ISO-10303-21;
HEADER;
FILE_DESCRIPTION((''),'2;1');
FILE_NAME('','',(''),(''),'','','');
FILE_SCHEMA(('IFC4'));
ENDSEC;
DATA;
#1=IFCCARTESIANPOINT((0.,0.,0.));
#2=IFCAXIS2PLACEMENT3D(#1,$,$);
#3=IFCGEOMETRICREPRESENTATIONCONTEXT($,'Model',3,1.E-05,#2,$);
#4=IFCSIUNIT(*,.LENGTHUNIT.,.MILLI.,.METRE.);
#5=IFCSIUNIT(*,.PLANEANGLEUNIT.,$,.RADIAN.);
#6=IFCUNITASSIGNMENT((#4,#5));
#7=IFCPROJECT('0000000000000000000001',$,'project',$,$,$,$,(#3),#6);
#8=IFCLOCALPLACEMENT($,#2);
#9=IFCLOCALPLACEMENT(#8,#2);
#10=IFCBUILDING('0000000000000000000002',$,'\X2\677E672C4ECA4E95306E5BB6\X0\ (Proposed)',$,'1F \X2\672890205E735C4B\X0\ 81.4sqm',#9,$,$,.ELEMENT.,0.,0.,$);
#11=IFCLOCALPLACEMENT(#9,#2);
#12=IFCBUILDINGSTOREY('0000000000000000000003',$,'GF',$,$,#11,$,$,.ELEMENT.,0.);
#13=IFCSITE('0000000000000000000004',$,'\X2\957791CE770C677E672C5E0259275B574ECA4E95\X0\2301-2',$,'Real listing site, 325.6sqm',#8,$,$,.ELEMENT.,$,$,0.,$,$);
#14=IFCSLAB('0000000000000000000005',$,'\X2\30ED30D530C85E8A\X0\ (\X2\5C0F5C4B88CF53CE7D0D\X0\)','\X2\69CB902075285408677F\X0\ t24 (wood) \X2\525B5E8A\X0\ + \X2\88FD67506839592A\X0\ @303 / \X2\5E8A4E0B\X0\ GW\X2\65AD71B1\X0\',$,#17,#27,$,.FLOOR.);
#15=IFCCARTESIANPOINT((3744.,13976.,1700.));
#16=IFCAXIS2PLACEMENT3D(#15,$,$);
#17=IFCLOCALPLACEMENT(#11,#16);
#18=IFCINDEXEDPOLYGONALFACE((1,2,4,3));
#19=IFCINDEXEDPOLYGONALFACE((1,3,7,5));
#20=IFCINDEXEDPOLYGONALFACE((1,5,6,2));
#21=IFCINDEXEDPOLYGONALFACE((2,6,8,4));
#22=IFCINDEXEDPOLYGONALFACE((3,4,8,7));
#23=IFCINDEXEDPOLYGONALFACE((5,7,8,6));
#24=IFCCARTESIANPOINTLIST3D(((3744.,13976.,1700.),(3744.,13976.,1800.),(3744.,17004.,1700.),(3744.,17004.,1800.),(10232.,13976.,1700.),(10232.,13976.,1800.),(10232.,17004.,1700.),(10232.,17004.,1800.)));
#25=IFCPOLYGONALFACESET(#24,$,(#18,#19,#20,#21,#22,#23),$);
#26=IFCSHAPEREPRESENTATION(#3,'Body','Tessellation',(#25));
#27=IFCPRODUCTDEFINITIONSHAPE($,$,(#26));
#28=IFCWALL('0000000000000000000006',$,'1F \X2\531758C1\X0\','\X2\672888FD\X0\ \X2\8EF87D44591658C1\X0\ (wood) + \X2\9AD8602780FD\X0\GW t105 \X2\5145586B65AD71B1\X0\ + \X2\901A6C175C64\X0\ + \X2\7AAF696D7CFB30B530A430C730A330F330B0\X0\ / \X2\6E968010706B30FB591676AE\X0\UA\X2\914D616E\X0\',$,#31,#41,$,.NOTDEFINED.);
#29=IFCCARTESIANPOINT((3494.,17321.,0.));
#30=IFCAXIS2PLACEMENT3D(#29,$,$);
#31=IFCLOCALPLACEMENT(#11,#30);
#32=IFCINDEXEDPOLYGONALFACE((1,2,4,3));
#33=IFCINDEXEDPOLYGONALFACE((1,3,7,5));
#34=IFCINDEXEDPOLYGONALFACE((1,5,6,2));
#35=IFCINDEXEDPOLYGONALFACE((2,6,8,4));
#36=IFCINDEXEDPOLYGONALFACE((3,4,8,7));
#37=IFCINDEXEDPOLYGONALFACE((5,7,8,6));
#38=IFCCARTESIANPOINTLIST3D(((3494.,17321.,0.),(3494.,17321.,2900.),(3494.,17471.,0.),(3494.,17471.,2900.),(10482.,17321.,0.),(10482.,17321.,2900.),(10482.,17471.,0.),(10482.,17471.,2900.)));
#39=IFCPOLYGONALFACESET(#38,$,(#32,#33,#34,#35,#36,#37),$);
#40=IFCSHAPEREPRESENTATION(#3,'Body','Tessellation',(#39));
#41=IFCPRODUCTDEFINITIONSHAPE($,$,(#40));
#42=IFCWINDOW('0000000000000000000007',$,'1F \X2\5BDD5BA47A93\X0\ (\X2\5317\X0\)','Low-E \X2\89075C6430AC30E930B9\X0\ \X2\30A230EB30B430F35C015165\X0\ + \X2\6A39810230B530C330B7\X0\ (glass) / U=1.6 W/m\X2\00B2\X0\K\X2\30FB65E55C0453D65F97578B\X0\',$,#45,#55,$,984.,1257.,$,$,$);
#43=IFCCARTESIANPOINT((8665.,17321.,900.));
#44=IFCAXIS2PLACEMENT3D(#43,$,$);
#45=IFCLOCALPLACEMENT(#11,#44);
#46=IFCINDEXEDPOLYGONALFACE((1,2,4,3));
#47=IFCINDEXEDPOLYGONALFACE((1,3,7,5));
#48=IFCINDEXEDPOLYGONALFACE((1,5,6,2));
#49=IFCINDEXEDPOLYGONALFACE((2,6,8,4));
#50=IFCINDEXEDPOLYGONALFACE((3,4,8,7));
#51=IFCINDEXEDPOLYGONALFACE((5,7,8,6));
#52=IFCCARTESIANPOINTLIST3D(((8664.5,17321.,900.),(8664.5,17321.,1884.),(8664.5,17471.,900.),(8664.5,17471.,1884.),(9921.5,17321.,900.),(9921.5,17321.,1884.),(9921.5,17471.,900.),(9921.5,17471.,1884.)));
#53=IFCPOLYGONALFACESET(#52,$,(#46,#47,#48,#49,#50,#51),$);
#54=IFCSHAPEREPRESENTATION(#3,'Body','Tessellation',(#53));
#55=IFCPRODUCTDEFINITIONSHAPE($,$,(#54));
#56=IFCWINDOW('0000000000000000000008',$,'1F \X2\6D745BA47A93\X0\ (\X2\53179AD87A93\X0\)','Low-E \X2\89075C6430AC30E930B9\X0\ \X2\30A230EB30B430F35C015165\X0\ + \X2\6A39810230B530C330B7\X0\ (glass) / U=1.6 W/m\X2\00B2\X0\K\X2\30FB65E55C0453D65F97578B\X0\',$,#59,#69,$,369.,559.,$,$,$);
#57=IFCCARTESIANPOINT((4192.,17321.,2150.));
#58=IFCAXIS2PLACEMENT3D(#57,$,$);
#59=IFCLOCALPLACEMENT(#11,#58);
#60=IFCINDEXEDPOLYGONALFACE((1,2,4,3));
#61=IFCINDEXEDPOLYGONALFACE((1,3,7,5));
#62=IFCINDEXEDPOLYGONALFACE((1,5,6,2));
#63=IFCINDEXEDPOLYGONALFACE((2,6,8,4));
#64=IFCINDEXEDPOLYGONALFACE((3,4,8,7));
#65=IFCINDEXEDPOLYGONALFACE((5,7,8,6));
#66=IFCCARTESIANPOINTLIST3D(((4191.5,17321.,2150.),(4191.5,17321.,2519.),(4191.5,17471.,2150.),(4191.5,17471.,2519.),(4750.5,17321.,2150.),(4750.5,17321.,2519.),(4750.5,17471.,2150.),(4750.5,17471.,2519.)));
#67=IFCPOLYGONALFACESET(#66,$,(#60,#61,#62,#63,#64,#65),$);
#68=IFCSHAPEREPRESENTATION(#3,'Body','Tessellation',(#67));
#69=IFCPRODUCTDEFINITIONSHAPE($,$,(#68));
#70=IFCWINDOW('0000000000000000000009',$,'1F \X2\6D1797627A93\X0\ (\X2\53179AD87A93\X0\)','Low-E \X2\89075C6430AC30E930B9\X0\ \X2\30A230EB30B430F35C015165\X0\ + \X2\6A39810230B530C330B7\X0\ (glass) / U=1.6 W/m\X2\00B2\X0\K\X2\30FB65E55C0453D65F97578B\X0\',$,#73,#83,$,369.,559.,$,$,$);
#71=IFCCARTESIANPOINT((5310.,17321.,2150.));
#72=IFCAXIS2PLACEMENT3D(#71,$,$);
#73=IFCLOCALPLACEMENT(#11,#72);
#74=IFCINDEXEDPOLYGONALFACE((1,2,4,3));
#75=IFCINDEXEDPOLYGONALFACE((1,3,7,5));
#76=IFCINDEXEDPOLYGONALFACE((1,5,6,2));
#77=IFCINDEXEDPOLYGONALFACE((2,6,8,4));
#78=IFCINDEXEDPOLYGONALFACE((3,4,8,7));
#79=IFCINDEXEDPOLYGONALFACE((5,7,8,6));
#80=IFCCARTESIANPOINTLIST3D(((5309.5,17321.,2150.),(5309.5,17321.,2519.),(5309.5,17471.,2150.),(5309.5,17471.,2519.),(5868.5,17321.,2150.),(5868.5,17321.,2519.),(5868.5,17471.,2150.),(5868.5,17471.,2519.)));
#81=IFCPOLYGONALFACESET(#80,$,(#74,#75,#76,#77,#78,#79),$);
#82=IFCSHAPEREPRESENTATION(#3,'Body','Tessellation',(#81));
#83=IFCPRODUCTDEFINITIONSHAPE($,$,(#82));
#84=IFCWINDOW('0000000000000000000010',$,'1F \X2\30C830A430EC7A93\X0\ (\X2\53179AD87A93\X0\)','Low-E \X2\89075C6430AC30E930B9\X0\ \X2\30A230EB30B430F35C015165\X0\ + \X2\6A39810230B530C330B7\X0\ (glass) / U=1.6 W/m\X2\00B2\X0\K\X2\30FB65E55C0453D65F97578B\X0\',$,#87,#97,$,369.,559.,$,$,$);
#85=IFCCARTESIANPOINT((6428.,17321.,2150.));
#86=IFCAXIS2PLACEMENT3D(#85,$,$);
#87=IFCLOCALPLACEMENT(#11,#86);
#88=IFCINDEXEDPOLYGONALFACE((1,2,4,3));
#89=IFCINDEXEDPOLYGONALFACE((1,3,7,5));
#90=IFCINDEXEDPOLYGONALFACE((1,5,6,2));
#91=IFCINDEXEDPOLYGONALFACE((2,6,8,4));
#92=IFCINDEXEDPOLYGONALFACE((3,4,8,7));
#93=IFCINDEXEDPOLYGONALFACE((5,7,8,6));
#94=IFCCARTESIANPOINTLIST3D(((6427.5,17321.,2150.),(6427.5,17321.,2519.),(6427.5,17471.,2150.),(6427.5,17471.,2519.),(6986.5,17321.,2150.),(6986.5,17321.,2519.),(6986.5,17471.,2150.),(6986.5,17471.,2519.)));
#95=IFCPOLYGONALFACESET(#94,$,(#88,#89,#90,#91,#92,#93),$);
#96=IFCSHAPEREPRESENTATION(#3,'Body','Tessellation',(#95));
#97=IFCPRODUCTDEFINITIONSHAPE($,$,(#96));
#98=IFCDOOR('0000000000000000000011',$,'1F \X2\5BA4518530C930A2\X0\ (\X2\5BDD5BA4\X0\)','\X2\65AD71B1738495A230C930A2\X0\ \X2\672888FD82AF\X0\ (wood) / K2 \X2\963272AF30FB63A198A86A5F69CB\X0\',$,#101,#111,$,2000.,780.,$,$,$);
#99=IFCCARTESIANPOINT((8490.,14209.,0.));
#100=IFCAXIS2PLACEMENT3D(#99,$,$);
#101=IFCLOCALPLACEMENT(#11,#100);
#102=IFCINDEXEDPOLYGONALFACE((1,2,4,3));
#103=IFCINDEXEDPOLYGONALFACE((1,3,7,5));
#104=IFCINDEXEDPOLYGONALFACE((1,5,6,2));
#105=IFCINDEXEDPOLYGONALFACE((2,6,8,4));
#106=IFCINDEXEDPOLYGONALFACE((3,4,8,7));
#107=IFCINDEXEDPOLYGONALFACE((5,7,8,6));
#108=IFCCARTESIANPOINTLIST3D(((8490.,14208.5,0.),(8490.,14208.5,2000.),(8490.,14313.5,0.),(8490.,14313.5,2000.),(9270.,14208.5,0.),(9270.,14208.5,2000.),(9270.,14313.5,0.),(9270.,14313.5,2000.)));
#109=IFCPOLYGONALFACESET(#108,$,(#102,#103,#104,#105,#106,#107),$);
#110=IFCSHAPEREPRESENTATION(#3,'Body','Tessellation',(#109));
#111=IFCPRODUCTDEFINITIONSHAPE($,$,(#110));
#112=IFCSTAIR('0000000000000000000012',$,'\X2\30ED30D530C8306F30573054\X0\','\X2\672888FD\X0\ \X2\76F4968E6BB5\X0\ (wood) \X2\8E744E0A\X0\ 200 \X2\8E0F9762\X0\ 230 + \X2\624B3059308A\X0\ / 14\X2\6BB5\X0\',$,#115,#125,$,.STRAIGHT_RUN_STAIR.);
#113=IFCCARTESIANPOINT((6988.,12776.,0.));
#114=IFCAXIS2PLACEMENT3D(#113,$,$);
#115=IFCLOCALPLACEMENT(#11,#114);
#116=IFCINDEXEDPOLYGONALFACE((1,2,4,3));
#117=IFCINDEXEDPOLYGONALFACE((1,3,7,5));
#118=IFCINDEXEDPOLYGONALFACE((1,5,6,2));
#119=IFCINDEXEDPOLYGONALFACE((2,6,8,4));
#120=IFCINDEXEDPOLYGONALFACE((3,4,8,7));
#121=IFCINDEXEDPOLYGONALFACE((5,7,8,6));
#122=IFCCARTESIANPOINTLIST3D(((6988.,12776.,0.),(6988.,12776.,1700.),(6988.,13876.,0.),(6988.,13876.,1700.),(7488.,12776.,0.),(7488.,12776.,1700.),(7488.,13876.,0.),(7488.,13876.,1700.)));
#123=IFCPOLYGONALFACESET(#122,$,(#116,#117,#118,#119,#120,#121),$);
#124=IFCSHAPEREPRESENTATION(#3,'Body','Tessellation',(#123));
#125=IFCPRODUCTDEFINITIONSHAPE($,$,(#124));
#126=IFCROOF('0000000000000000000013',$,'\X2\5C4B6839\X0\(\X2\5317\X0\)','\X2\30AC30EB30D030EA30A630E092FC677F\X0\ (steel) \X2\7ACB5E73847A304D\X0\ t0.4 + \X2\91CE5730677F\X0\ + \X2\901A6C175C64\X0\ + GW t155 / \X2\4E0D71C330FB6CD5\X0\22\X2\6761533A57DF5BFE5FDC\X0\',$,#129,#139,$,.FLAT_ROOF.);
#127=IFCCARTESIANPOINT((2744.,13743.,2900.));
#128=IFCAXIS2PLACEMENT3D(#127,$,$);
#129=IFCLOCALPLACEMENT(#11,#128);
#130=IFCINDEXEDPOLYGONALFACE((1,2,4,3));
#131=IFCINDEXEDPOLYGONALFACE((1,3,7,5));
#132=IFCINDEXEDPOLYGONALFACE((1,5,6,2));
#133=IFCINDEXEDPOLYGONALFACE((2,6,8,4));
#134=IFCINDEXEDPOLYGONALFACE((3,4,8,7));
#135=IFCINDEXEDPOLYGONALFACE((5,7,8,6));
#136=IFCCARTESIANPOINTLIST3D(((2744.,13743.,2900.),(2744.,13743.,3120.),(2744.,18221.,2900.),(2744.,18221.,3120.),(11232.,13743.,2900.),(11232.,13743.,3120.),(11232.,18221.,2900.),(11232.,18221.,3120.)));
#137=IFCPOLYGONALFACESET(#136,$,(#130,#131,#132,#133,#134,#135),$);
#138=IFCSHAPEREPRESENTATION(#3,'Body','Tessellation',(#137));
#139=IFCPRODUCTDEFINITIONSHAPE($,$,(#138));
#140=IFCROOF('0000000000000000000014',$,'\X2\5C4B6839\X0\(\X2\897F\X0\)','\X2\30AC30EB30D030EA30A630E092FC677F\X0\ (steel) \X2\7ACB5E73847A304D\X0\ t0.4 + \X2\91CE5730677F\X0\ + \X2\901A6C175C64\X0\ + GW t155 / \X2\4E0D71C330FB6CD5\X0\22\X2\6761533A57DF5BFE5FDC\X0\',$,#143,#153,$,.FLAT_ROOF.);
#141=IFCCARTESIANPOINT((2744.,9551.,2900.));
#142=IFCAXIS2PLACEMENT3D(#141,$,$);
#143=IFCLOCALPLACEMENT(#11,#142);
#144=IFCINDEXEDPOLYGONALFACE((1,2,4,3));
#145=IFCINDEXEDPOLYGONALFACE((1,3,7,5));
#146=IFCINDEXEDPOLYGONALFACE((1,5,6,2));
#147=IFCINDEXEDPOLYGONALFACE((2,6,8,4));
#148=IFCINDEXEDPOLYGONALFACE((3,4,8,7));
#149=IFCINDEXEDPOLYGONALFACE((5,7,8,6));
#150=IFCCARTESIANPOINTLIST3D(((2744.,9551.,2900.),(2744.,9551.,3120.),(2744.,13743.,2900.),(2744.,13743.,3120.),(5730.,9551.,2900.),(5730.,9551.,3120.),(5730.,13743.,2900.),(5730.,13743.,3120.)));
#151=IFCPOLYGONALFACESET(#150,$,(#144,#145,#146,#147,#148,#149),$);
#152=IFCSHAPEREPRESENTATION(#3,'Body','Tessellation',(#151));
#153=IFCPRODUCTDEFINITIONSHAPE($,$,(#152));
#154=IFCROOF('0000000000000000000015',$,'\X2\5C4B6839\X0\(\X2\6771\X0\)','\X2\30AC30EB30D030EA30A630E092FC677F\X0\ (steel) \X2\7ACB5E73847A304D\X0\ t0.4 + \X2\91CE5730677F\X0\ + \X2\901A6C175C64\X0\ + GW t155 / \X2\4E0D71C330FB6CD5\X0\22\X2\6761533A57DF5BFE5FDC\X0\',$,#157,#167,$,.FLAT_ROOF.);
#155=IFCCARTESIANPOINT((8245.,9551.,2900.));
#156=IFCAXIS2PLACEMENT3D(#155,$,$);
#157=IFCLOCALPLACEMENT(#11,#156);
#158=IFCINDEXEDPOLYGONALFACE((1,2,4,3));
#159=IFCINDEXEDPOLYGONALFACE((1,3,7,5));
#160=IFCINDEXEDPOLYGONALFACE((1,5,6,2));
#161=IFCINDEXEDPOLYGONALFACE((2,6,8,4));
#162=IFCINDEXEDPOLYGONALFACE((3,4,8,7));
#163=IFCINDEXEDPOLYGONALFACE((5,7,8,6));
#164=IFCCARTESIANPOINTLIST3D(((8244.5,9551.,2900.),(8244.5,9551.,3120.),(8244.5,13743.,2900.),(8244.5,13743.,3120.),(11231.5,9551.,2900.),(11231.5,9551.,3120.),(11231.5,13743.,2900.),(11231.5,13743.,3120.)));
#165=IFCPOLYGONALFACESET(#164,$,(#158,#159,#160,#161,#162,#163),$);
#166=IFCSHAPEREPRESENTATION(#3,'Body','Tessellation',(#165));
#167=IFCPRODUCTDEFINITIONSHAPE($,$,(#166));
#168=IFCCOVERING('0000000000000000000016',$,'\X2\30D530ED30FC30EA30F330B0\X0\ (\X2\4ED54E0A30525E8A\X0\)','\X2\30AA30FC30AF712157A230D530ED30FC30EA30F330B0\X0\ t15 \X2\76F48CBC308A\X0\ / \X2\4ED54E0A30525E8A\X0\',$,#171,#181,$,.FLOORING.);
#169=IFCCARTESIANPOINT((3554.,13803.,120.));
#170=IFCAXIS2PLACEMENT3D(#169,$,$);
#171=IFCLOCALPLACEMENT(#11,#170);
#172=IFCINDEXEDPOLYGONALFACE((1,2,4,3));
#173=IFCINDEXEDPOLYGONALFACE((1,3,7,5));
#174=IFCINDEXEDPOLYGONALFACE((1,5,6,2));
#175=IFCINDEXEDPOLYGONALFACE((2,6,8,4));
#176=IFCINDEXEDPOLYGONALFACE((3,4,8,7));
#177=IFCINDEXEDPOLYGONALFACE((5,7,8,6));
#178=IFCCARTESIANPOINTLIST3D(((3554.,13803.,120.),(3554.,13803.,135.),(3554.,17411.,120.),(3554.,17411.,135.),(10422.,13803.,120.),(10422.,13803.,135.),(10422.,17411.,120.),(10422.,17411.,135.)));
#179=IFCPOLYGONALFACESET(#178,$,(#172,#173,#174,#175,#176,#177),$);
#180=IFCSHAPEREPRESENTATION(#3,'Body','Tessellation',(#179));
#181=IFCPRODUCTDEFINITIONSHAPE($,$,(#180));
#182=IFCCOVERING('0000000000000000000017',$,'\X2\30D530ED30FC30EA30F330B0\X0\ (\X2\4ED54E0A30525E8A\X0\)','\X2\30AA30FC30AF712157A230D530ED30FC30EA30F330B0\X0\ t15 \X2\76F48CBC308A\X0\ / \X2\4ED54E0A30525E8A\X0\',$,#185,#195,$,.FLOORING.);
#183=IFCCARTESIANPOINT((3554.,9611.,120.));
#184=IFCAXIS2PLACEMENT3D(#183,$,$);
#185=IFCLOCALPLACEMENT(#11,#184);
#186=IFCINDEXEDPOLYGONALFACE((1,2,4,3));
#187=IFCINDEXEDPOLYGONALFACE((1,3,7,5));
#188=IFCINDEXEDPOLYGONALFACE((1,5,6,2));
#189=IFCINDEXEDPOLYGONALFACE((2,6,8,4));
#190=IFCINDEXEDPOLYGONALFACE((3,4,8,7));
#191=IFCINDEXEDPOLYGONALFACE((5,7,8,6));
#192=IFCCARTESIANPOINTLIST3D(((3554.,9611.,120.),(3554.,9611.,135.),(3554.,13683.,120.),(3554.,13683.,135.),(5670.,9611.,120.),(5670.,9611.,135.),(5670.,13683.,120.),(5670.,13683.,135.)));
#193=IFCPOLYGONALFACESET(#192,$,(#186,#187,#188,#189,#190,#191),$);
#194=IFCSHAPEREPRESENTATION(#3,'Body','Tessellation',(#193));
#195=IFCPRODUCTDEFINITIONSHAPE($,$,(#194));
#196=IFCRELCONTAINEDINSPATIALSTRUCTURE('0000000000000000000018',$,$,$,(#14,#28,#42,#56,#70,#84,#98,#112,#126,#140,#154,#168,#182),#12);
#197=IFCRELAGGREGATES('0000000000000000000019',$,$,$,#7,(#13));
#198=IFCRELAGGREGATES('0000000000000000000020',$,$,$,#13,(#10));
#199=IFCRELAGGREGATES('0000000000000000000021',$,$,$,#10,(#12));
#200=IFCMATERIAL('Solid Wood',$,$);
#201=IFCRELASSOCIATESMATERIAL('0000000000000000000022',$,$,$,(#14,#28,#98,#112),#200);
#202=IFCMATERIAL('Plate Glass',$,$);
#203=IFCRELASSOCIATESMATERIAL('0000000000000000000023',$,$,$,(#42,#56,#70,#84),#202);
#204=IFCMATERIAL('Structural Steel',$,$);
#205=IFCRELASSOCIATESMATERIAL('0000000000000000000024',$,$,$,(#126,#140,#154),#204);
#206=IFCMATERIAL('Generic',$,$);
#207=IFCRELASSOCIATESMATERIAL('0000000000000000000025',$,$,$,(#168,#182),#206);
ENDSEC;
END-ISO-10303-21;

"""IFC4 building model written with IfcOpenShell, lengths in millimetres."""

from ifc_helpers import new_model, si_unit, frame, frame_2d, origin, place, context, project, spatial, rectangle, extrude, material, element, fill, save


model = new_model("IFC4")

# Units and contexts
model_context = context("Model", 3, precision=1e-05, world=origin())
ifc_project = project(units=[si_unit("LENGTHUNIT", "METRE", prefix="MILLI"), si_unit("PLANEANGLEUNIT", "RADIAN")], contexts=[model_context])

# Site, building, storey
site_placement = place(None, origin())
site = spatial("IfcSite", under=ifc_project, at=site_placement, Name="長野県松本市大字今井2301-2", ObjectType="Real listing site, 325.6sqm", CompositionType="ELEMENT", RefElevation=0.0)
building_placement = place(site_placement, origin())
building = spatial("IfcBuilding", under=site, at=building_placement, Name="松本今井の家 (Proposed)", ObjectType="1F 木造平屋 81.4sqm", CompositionType="ELEMENT", ElevationOfRefHeight=0.0, ElevationOfTerrain=0.0)
storey_placement = place(building_placement, origin())
storey = spatial("IfcBuildingStorey", under=building, at=storey_placement, Name="GF", CompositionType="ELEMENT", Elevation=0.0)

# Slab
ifc_material_1 = material(Name="Solid Wood")
slab_1_placement = place(storey_placement, frame((3744.0, 13976.0, 1700.0)))
element("IfcSlab", 1, at=slab_1_placement, inside=storey, material=ifc_material_1, Name="ロフト床 (小屋裏収納)", Description="構造用合板 t24 (wood) 剛床 + 製材根太 @303 / 床下 GW断熱", PredefinedType="FLOOR", context=model_context, shape_type="SweptSolid", body=[
    extrude(rectangle(XDim=6488.0, YDim=3028.0, at=frame_2d((3244.0, 1514.0))), frame((3744.0, 13976.0, 1700.0)), (0.0, 0.0, 1.0), 100.0),
])

# Wall, openings, windows
wall_1_placement = place(storey_placement, frame((3494.0, 17321.0, 0.0)))
wall_1 = element("IfcWall", 2, at=wall_1_placement, inside=storey, material=ifc_material_1, Name="1F 北壁", Description="木製 軸組外壁 (wood) + 高性能GW t105 充填断熱 + 通気層 + 窯業系サイディング / 準耐火・外皮UA配慮", PredefinedType="NOTDEFINED", context=model_context, shape_type="SweptSolid", body=[
    extrude(rectangle(XDim=6988.0, YDim=150.0, at=frame_2d((3494.0, 75.0))), frame((3494.0, 17321.0, 0.0)), (0.0, 0.0, 1.0), 2900.0),
])
opening_1_placement = place(storey_placement, frame((8665.0, 17321.0, 900.0)))
opening_1 = element("IfcOpeningElement", 3, at=opening_1_placement, cuts=wall_1, PredefinedType="NOTDEFINED", context=model_context, shape_type="SweptSolid", body=[
    extrude(rectangle(XDim=1257.0, YDim=150.0, at=frame_2d((628.0, 75.0))), frame((8665.0, 17321.0, 900.0)), (0.0, 0.0, 1.0), 984.0),
])
opening_2_placement = place(storey_placement, frame((4192.0, 17321.0, 2150.0)))
opening_2 = element("IfcOpeningElement", 4, at=opening_2_placement, cuts=wall_1, PredefinedType="NOTDEFINED", context=model_context, shape_type="SweptSolid", body=[
    extrude(rectangle(XDim=559.0, YDim=150.0, at=frame_2d((279.0, 75.0))), frame((4192.0, 17321.0, 2150.0)), (0.0, 0.0, 1.0), 369.0),
])
opening_3_placement = place(storey_placement, frame((5310.0, 17321.0, 2150.0)))
opening_3 = element("IfcOpeningElement", 5, at=opening_3_placement, cuts=wall_1, PredefinedType="NOTDEFINED", context=model_context, shape_type="SweptSolid", body=[
    extrude(rectangle(XDim=559.0, YDim=150.0, at=frame_2d((279.0, 75.0))), frame((5310.0, 17321.0, 2150.0)), (0.0, 0.0, 1.0), 369.0),
])
opening_4_placement = place(storey_placement, frame((6428.0, 17321.0, 2150.0)))
opening_4 = element("IfcOpeningElement", 6, at=opening_4_placement, cuts=wall_1, PredefinedType="NOTDEFINED", context=model_context, shape_type="SweptSolid", body=[
    extrude(rectangle(XDim=559.0, YDim=150.0, at=frame_2d((279.0, 75.0))), frame((6428.0, 17321.0, 2150.0)), (0.0, 0.0, 1.0), 369.0),
])
ifc_material_2 = material(Name="Plate Glass")
window_1_placement = place(storey_placement, frame((8665.0, 17321.0, 900.0)))
window_1 = element("IfcWindow", 7, at=window_1_placement, inside=storey, material=ifc_material_2, Name="1F 寝室窓 (北)", Description="Low-E 複層ガラス アルゴン封入 + 樹脂サッシ (glass) / U=1.6 W/m²K・日射取得型", OverallHeight=984.0, OverallWidth=1257.0, context=model_context, shape_type="SweptSolid", body=[
    extrude(rectangle(XDim=1257.0, YDim=150.0, at=frame_2d((628.0, 75.0))), frame((8665.0, 17321.0, 900.0)), (0.0, 0.0, 1.0), 984.0),
])
fill(opening_1, window_1)
window_2_placement = place(storey_placement, frame((4192.0, 17321.0, 2150.0)))
window_2 = element("IfcWindow", 8, at=window_2_placement, inside=storey, material=ifc_material_2, Name="1F 浴室窓 (北高窓)", Description="Low-E 複層ガラス アルゴン封入 + 樹脂サッシ (glass) / U=1.6 W/m²K・日射取得型", OverallHeight=369.0, OverallWidth=559.0, context=model_context, shape_type="SweptSolid", body=[
    extrude(rectangle(XDim=559.0, YDim=150.0, at=frame_2d((279.0, 75.0))), frame((4192.0, 17321.0, 2150.0)), (0.0, 0.0, 1.0), 369.0),
])
fill(opening_2, window_2)
window_3_placement = place(storey_placement, frame((5310.0, 17321.0, 2150.0)))
window_3 = element("IfcWindow", 9, at=window_3_placement, inside=storey, material=ifc_material_2, Name="1F 洗面窓 (北高窓)", Description="Low-E 複層ガラス アルゴン封入 + 樹脂サッシ (glass) / U=1.6 W/m²K・日射取得型", OverallHeight=369.0, OverallWidth=559.0, context=model_context, shape_type="SweptSolid", body=[
    extrude(rectangle(XDim=559.0, YDim=150.0, at=frame_2d((279.0, 75.0))), frame((5310.0, 17321.0, 2150.0)), (0.0, 0.0, 1.0), 369.0),
])
fill(opening_3, window_3)
window_4_placement = place(storey_placement, frame((6428.0, 17321.0, 2150.0)))
window_4 = element("IfcWindow", 10, at=window_4_placement, inside=storey, material=ifc_material_2, Name="1F トイレ窓 (北高窓)", Description="Low-E 複層ガラス アルゴン封入 + 樹脂サッシ (glass) / U=1.6 W/m²K・日射取得型", OverallHeight=369.0, OverallWidth=559.0, context=model_context, shape_type="SweptSolid", body=[
    extrude(rectangle(XDim=559.0, YDim=150.0, at=frame_2d((279.0, 75.0))), frame((6428.0, 17321.0, 2150.0)), (0.0, 0.0, 1.0), 369.0),
])
fill(opening_4, window_4)

# Door
door_1_placement = place(storey_placement, frame((8490.0, 14209.0, 0.0)))
element("IfcDoor", 11, at=door_1_placement, inside=storey, material=ifc_material_1, Name="1F 室内ドア (寝室)", Description="断熱玄関ドア 木製芯 (wood) / K2 防犯・採風機構", OverallHeight=2000.0, OverallWidth=780.0, context=model_context, shape_type="SweptSolid", body=[
    extrude(rectangle(XDim=780.0, YDim=105.0, at=frame_2d((390.0, 52.0))), frame((8490.0, 14209.0, 0.0)), (0.0, 0.0, 1.0), 2000.0),
])

# Stair
stair_placement = place(storey_placement, frame((6988.0, 12776.0, 0.0)))
element("IfcStair", 12, at=stair_placement, inside=storey, material=ifc_material_1, Name="ロフトはしご", Description="木製 直階段 (wood) 蹴上 200 踏面 230 + 手すり / 14段", PredefinedType="STRAIGHT_RUN_STAIR", context=model_context, shape_type="SweptSolid", body=[
    extrude(rectangle(XDim=500.0, YDim=1100.0, at=frame_2d((250.0, 550.0))), frame((6988.0, 12776.0, 0.0)), (0.0, 0.0, 1.0), 1700.0),
])

# Roofs
ifc_material_3 = material(Name="Structural Steel")
roof_1_placement = place(storey_placement, frame((2744.0, 13743.0, 2900.0)))
element("IfcRoof", 13, at=roof_1_placement, inside=storey, material=ifc_material_3, Name="屋根(北)", Description="ガルバリウム鋼板 (steel) 立平葺き t0.4 + 野地板 + 通気層 + GW t155 / 不燃・法22条区域対応", PredefinedType="FLAT_ROOF", context=model_context, shape_type="SweptSolid", body=[
    extrude(rectangle(XDim=8488.0, YDim=4478.0, at=frame_2d((4244.0, 2239.0))), frame((2744.0, 13743.0, 2900.0)), (0.0, 0.0, 1.0), 220.0),
])
roof_2_placement = place(storey_placement, frame((2744.0, 9551.0, 2900.0)))
element("IfcRoof", 14, at=roof_2_placement, inside=storey, material=ifc_material_3, Name="屋根(西)", Description="ガルバリウム鋼板 (steel) 立平葺き t0.4 + 野地板 + 通気層 + GW t155 / 不燃・法22条区域対応", PredefinedType="FLAT_ROOF", context=model_context, shape_type="SweptSolid", body=[
    extrude(rectangle(XDim=2986.0, YDim=4192.0, at=frame_2d((1493.0, 2096.0))), frame((2744.0, 9551.0, 2900.0)), (0.0, 0.0, 1.0), 220.0),
])
roof_3_placement = place(storey_placement, frame((8245.0, 9551.0, 2900.0)))
element("IfcRoof", 15, at=roof_3_placement, inside=storey, material=ifc_material_3, Name="屋根(東)", Description="ガルバリウム鋼板 (steel) 立平葺き t0.4 + 野地板 + 通気層 + GW t155 / 不燃・法22条区域対応", PredefinedType="FLAT_ROOF", context=model_context, shape_type="SweptSolid", body=[
    extrude(rectangle(XDim=2987.0, YDim=4192.0, at=frame_2d((1493.0, 2096.0))), frame((8245.0, 9551.0, 2900.0)), (0.0, 0.0, 1.0), 220.0),
])

# Coverings
ifc_material_4 = material(Name="Generic")
covering_1_placement = place(storey_placement, frame((3554.0, 13803.0, 120.0)))
element("IfcCovering", 16, at=covering_1_placement, inside=storey, material=ifc_material_4, Name="フローリング (仕上げ床)", Description="オーク無垢フローリング t15 直貼り / 仕上げ床", PredefinedType="FLOORING", context=model_context, shape_type="SweptSolid", body=[
    extrude(rectangle(XDim=6868.0, YDim=3608.0, at=frame_2d((3434.0, 1804.0))), frame((3554.0, 13803.0, 120.0)), (0.0, 0.0, 1.0), 15.0),
])
covering_2_placement = place(storey_placement, frame((3554.0, 9611.0, 120.0)))
element("IfcCovering", 17, at=covering_2_placement, inside=storey, material=ifc_material_4, Name="フローリング (仕上げ床)", Description="オーク無垢フローリング t15 直貼り / 仕上げ床", PredefinedType="FLOORING", context=model_context, shape_type="SweptSolid", body=[
    extrude(rectangle(XDim=2116.0, YDim=4072.0, at=frame_2d((1058.0, 2036.0))), frame((3554.0, 9611.0, 120.0)), (0.0, 0.0, 1.0), 15.0),
])

save(model, "model.ifc")
